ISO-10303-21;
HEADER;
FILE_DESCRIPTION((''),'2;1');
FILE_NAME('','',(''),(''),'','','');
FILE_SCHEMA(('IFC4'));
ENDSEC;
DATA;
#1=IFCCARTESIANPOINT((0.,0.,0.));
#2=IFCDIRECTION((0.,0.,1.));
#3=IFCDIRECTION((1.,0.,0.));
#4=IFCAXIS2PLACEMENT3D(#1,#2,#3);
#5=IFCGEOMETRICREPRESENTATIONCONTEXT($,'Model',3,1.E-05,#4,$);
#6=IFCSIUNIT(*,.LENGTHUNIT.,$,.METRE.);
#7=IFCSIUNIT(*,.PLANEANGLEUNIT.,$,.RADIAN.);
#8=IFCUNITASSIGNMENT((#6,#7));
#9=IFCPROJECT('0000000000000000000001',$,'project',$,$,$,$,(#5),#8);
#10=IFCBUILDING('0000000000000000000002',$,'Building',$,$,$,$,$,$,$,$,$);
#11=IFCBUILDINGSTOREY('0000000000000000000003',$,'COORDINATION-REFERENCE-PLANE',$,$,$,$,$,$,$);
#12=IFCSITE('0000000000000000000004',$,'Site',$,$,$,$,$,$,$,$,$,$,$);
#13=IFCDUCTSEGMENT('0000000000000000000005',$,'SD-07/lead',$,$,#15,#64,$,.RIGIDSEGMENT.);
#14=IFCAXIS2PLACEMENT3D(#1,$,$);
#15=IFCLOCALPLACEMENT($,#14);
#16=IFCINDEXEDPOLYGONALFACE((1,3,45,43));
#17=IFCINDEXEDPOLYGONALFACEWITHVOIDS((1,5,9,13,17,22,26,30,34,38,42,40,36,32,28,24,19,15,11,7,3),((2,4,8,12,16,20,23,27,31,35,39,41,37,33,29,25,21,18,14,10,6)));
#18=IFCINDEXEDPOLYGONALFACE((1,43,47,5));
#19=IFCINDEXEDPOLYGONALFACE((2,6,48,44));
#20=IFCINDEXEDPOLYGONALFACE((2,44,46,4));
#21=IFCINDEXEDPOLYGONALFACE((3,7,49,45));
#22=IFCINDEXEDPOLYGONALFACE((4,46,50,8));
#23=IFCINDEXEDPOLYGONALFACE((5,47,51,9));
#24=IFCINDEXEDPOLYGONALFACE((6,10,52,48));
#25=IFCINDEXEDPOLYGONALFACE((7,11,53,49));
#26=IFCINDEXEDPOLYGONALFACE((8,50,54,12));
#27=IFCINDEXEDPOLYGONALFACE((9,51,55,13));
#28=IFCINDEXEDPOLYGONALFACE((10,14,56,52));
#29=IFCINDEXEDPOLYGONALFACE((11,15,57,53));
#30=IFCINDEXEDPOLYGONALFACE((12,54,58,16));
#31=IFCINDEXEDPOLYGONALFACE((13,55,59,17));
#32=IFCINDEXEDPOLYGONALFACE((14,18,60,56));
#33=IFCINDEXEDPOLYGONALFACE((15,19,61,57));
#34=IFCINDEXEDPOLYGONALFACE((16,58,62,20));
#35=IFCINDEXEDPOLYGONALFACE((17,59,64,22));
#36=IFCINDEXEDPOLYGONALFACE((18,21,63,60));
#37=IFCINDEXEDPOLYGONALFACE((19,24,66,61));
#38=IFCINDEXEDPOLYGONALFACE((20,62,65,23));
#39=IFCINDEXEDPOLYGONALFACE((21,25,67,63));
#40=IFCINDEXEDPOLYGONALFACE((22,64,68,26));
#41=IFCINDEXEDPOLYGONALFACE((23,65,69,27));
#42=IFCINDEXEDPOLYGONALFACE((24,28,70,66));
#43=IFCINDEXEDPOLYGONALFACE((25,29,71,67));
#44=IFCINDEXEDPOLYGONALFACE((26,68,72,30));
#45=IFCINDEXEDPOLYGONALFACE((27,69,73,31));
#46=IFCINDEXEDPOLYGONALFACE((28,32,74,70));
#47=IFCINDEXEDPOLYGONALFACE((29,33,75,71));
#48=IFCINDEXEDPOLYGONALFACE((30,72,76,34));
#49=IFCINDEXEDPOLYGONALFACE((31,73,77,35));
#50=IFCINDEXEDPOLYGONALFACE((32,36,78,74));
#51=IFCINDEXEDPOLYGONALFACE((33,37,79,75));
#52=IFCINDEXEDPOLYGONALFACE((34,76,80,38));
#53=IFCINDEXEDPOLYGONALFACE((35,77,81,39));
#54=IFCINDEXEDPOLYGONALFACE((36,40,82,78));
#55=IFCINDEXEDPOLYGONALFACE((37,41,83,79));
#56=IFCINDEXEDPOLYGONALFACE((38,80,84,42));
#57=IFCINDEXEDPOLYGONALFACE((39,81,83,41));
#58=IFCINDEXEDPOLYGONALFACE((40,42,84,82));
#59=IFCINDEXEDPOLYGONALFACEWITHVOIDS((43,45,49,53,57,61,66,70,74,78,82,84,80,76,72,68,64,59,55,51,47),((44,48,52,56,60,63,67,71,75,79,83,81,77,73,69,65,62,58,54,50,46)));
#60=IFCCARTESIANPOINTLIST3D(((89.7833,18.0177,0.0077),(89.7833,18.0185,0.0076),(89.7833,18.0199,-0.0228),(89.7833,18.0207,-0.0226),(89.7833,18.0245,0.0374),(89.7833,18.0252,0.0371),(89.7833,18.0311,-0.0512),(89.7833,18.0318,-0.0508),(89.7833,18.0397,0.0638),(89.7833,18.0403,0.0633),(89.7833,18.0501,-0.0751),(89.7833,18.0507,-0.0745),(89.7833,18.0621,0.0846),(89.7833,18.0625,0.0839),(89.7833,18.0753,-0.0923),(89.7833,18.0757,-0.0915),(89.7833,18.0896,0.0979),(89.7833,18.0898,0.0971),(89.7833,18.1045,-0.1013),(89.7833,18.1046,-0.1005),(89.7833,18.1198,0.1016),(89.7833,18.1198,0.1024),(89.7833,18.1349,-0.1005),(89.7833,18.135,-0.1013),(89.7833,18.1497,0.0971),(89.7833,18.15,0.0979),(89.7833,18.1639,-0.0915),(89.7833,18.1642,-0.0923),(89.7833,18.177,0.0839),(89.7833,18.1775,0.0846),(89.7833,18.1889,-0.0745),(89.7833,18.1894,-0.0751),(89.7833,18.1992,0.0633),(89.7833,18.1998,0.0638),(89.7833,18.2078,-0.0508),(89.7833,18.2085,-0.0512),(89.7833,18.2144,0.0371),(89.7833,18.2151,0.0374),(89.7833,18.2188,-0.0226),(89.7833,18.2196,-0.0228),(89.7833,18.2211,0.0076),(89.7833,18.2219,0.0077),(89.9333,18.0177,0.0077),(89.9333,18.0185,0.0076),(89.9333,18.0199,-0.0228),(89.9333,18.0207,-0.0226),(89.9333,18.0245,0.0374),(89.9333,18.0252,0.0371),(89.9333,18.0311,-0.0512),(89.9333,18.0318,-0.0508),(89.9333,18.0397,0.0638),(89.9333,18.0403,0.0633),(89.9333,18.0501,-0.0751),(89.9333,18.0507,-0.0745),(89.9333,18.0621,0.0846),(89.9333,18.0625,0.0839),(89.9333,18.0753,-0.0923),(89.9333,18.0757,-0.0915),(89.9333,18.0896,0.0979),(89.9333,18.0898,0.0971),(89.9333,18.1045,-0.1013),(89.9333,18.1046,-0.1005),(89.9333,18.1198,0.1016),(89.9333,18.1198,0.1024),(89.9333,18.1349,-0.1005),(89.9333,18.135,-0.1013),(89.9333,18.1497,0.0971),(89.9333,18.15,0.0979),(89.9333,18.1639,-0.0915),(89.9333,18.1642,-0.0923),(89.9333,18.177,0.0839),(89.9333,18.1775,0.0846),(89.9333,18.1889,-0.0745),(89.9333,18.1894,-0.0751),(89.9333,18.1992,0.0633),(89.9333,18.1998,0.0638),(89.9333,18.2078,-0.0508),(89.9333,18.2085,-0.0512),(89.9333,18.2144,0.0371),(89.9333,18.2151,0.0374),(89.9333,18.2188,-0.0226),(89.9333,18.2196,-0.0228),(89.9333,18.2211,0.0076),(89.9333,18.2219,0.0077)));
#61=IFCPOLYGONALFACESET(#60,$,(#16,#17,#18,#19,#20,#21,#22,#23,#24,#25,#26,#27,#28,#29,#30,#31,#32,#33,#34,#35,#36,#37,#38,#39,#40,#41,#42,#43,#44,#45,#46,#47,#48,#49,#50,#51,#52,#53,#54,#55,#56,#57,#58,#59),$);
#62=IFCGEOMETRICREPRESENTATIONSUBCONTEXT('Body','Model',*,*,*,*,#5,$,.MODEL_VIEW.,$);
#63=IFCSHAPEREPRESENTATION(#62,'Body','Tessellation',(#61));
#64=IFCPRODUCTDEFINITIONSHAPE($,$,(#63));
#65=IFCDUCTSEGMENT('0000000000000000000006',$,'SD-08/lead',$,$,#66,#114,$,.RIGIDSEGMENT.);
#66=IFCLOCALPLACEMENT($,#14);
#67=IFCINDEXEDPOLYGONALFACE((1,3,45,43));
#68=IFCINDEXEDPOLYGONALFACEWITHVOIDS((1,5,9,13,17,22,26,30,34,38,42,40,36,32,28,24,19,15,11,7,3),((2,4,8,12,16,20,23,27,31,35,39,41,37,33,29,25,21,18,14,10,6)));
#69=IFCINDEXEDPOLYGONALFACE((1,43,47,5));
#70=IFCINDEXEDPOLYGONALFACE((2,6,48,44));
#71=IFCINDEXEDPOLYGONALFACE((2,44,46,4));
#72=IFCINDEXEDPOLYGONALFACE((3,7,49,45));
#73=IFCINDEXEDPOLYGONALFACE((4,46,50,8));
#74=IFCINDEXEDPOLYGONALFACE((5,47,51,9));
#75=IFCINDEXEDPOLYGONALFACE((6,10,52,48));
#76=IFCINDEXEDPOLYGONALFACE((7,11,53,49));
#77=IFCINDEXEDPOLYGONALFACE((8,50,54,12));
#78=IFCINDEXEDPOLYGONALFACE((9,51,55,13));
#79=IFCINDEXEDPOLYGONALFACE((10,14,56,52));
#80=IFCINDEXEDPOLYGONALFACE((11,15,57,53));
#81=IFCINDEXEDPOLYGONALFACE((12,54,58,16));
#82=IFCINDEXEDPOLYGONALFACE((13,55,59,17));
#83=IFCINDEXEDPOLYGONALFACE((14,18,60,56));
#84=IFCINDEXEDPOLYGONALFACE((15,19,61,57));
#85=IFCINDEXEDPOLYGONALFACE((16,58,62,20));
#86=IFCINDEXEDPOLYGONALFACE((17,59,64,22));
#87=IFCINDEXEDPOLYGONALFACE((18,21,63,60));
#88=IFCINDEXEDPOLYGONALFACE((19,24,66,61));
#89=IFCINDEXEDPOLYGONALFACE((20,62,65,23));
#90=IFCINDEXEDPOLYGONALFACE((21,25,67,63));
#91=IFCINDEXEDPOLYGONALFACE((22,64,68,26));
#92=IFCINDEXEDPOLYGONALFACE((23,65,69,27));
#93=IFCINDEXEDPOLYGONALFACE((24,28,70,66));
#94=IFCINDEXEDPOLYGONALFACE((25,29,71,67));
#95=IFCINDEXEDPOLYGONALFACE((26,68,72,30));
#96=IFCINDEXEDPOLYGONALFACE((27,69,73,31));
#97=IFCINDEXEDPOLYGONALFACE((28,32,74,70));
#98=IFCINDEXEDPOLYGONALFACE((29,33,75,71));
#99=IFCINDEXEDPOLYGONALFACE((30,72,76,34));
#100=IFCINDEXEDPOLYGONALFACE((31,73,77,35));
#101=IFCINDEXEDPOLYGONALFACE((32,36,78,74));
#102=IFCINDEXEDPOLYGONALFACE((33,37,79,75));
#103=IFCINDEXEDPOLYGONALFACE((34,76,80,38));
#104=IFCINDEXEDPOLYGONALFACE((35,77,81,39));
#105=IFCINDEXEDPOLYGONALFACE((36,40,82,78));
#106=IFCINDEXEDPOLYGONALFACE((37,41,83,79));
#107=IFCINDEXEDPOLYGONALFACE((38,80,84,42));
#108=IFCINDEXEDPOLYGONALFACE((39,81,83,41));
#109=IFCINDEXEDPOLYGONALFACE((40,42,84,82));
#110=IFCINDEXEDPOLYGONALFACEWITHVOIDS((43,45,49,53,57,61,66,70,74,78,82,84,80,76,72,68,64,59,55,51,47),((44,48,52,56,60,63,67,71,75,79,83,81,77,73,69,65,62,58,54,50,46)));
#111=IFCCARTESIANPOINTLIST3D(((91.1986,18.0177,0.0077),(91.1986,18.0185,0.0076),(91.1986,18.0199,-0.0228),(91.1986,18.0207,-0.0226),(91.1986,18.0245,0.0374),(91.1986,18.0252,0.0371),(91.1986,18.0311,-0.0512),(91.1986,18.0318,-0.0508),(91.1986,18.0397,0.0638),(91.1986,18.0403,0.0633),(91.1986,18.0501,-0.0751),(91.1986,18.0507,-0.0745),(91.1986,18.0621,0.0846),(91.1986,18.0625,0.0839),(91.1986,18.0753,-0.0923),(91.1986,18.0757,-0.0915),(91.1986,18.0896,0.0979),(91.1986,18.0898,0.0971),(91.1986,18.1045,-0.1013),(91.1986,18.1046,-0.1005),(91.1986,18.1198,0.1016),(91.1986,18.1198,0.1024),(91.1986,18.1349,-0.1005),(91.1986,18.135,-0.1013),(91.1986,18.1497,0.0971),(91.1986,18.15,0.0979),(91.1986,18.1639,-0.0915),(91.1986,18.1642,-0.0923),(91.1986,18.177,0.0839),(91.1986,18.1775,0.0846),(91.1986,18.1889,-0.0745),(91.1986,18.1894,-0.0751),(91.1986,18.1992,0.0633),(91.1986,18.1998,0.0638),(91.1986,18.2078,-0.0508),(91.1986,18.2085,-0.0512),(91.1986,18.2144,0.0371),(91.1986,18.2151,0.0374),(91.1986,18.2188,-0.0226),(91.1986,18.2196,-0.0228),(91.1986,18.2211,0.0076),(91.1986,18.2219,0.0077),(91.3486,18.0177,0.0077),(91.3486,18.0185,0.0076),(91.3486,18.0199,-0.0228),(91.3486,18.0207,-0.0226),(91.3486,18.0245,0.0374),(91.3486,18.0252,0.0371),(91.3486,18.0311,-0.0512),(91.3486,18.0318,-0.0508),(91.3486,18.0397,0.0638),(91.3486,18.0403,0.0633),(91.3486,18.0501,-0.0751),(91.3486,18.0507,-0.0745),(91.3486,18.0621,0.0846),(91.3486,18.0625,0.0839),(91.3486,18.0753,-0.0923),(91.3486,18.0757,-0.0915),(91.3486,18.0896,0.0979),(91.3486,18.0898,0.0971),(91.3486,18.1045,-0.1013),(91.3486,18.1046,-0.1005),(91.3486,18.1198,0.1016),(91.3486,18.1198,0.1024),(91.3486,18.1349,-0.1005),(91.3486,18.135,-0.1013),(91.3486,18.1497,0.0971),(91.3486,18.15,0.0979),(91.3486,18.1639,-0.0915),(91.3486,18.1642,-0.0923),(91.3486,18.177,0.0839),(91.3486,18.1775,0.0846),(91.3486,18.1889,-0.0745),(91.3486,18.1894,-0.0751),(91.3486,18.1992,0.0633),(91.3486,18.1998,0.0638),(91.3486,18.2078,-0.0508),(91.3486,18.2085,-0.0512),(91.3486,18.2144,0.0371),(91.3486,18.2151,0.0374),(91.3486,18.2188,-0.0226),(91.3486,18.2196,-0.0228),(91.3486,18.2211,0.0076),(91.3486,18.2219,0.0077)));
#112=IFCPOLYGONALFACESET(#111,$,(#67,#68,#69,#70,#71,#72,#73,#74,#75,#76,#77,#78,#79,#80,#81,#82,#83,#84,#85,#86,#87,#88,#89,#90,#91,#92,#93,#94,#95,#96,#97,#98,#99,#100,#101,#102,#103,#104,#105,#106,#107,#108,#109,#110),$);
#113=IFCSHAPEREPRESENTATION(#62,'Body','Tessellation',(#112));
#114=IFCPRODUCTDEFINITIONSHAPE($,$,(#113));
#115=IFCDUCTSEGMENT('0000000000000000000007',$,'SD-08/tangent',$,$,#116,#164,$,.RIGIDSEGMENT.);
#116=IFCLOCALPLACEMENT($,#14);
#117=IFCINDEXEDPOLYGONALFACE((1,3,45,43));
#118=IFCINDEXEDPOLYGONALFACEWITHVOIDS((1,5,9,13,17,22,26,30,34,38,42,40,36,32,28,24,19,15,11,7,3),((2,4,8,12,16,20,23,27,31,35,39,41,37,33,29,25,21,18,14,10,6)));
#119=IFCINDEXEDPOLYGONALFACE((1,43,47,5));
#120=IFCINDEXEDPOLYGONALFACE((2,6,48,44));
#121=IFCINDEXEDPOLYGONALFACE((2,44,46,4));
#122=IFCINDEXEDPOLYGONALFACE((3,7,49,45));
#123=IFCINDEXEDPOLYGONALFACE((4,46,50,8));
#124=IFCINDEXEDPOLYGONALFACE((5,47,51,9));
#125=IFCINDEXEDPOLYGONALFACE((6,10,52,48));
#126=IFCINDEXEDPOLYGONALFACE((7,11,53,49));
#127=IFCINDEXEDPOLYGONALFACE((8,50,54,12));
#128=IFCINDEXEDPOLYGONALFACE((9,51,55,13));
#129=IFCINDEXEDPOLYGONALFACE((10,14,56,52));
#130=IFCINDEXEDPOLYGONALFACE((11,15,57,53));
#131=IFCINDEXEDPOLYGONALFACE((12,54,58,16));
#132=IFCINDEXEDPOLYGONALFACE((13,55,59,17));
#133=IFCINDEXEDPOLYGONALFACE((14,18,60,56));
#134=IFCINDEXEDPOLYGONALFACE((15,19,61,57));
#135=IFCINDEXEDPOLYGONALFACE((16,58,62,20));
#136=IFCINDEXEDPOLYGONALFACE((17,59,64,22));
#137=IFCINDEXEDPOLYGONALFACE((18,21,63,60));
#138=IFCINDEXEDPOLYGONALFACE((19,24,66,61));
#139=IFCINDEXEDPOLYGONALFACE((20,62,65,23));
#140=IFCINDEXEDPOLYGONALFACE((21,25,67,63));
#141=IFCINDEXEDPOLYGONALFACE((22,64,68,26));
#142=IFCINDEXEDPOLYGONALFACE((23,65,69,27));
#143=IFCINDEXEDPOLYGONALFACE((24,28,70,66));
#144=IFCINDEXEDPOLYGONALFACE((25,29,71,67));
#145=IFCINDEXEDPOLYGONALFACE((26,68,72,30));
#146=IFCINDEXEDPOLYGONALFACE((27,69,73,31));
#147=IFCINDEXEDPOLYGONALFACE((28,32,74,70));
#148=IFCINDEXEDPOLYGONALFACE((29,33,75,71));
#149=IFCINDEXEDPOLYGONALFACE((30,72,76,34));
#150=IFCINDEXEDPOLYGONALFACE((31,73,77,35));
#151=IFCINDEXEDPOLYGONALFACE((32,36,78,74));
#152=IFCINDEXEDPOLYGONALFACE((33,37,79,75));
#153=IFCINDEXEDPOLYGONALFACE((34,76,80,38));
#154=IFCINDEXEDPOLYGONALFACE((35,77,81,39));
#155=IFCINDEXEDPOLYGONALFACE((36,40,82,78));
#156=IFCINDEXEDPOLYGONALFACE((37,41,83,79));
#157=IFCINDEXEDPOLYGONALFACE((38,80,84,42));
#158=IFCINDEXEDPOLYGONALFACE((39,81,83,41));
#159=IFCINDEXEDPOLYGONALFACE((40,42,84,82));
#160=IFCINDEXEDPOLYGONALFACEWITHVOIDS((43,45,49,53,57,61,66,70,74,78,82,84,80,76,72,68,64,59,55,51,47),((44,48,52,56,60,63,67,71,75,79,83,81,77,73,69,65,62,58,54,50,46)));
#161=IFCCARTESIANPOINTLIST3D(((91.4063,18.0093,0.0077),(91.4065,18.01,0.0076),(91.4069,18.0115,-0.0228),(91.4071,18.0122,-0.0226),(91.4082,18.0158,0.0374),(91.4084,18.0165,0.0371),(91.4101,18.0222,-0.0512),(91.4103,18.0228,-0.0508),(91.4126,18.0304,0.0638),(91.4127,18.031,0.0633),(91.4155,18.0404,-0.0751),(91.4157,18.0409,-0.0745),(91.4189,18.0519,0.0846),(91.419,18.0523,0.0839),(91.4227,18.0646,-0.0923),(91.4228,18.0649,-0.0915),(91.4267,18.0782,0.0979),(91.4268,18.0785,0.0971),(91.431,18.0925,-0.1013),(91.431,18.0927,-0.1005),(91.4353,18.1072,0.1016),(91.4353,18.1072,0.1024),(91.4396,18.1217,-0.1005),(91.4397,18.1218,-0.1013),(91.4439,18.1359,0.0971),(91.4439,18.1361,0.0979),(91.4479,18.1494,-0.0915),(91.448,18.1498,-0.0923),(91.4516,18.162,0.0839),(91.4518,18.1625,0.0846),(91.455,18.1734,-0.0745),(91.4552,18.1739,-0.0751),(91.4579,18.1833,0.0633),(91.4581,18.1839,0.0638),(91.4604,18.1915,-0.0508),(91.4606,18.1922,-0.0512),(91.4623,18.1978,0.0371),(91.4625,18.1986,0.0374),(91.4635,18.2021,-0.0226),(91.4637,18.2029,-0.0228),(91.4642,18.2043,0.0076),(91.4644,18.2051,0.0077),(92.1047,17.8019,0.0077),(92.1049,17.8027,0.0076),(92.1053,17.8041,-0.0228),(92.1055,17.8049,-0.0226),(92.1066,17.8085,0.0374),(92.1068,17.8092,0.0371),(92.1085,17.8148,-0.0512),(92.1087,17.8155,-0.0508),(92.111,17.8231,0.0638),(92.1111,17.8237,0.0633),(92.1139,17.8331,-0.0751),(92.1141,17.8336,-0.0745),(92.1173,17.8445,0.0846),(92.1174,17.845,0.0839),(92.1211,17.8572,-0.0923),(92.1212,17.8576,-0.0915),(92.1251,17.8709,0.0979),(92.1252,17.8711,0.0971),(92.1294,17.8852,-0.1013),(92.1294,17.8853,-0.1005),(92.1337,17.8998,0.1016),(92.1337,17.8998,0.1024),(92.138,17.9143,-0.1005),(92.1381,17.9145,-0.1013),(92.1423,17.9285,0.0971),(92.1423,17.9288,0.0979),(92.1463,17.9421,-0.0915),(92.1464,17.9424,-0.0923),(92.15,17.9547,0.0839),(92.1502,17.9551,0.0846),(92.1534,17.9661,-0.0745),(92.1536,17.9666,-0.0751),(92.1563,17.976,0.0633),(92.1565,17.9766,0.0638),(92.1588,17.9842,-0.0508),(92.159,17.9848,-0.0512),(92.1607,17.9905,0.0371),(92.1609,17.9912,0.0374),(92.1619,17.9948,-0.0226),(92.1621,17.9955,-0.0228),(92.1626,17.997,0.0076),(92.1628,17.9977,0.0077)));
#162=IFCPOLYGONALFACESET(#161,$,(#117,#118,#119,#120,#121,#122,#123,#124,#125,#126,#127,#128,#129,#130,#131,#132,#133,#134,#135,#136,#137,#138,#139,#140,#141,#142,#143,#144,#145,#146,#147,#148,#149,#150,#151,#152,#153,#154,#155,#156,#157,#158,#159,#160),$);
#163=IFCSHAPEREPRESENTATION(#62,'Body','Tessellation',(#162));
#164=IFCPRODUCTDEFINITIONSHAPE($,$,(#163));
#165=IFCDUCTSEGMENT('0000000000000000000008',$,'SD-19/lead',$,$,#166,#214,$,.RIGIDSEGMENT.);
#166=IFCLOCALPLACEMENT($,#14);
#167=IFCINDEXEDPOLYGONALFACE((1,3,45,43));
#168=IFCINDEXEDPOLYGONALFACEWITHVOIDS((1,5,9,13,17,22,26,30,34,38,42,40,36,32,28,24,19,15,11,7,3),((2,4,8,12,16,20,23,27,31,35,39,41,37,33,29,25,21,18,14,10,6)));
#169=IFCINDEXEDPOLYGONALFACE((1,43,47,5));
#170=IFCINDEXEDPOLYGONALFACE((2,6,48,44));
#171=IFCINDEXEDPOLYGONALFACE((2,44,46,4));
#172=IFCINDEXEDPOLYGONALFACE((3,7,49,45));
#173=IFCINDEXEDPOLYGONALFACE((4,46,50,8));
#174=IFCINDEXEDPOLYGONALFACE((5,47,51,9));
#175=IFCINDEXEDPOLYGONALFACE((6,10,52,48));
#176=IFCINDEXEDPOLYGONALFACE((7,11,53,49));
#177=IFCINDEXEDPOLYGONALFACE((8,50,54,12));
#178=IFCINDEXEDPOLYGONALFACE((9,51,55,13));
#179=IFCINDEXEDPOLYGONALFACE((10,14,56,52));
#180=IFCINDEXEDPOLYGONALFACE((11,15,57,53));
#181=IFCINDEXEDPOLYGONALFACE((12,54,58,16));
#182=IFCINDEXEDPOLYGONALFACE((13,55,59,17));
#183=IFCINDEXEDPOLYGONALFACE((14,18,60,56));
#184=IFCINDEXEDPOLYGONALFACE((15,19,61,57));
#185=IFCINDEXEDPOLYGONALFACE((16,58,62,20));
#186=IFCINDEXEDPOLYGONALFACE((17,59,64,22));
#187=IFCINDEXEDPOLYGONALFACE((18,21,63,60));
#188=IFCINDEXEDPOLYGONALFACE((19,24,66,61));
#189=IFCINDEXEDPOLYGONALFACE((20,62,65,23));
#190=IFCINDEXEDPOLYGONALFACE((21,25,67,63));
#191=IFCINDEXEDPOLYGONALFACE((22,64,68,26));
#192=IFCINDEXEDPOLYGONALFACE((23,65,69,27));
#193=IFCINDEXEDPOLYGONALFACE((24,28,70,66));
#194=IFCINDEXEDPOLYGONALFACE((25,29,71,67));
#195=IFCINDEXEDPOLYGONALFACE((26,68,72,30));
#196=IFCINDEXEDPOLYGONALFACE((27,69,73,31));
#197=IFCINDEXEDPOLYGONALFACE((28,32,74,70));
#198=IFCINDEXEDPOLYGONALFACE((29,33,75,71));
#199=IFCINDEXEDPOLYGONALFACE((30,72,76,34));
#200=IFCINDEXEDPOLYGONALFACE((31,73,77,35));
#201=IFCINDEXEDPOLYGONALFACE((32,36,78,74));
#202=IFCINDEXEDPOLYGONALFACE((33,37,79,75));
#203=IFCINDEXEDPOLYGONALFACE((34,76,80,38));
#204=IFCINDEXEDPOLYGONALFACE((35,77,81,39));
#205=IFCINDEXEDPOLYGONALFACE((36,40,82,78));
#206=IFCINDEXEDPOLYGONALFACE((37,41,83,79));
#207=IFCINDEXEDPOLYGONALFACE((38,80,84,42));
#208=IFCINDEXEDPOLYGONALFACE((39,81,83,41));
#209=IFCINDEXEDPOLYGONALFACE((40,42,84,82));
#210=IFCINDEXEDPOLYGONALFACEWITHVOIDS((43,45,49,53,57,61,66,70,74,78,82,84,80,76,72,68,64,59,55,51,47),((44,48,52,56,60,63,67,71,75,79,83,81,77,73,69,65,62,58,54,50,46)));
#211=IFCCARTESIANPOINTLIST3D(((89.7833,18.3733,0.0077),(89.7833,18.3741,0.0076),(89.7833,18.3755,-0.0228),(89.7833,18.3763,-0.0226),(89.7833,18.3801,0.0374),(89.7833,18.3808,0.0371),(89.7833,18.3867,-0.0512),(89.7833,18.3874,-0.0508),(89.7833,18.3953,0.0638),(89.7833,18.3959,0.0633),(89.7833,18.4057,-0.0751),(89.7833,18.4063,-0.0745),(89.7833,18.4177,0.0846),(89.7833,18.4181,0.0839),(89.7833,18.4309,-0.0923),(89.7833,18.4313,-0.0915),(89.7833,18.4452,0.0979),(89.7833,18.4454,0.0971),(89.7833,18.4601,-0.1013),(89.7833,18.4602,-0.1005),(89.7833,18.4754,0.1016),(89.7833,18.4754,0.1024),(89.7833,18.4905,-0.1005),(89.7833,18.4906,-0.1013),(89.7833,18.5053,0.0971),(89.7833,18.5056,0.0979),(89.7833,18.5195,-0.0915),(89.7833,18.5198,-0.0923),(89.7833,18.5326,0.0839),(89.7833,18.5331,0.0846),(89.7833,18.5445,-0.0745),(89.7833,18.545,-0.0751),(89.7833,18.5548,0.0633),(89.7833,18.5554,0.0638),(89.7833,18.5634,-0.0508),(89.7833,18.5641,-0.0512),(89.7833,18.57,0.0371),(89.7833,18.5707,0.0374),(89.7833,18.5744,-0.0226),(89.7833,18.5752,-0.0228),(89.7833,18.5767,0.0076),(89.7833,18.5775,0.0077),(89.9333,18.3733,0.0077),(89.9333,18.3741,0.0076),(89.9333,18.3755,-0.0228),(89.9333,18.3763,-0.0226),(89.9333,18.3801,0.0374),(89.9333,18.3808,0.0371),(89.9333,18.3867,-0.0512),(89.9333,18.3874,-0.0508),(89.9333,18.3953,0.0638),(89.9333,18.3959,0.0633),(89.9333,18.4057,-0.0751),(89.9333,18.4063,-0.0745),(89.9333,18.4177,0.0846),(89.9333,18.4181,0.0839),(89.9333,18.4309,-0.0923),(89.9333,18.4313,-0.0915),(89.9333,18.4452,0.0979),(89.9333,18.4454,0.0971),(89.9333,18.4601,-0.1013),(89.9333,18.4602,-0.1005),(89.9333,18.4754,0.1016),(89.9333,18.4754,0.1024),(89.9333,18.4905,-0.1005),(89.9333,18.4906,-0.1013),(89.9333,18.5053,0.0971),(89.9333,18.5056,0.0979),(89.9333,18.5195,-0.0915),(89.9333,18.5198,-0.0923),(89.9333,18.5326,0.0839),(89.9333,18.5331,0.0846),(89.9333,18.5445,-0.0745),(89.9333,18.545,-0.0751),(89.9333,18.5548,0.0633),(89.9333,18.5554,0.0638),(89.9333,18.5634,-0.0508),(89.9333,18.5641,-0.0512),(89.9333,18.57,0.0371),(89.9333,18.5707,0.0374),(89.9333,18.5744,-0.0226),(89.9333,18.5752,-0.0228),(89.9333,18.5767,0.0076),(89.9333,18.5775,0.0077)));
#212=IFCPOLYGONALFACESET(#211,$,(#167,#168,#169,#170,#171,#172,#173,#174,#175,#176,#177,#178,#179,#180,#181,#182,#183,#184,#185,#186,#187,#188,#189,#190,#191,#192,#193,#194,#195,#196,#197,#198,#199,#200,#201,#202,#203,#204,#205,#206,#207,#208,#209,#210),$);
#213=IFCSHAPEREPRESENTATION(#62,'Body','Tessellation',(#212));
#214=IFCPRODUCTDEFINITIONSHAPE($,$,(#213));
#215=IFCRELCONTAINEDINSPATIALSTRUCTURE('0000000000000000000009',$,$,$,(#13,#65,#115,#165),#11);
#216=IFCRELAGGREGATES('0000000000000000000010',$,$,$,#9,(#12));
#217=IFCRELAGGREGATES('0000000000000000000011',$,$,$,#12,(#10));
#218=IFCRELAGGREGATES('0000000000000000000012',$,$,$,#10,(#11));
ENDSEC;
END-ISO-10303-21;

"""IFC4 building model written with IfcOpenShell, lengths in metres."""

from ifc_helpers import new_model, si_unit, frame, origin_with_axes, place, context, subcontext, project, spatial, hollow_circle, extrude, element, save


model = new_model("IFC4")

# Units and contexts
model_context = context("Model", 3, precision=1e-05, world=origin_with_axes())
body_context_1 = subcontext(model_context, "Body", "Model", "MODEL_VIEW")
ifc_project = project(units=[si_unit("LENGTHUNIT", "METRE"), si_unit("PLANEANGLEUNIT", "RADIAN")], contexts=[model_context])

# Site, building, storey
site = spatial("IfcSite", under=ifc_project, Name="Site")
building = spatial("IfcBuilding", under=site, Name="Building")
storey = spatial("IfcBuildingStorey", under=building, Name="COORDINATION-REFERENCE-PLANE")

# Duct segments
for number, where, z_axis, x_axis, name in (
    (1, (89.9333, 18.1198, 0.0), (-1.0, 0.0, 0.0), (0.0, 0.0, 1.0), "SD-07/lead"),
    (2, (91.1986, 18.1198, 0.0), (1.0, 0.0, 0.0), (0.0, 0.0, 1.0), "SD-08/lead"),
):
    element("IfcDuctSegment", number, at=place(None, frame(where, z_axis=z_axis, x_axis=x_axis)), inside=storey, Name=name, PredefinedType="RIGIDSEGMENT", context=body_context_1, shape_type="SweptSolid", body=[
        extrude(hollow_circle(Radius=0.1024, WallThickness=0.0008), origin_with_axes(), (0.0, 0.0, 1.0), 0.15),
    ])

# Duct segment
duct_segment_1_placement = place(None, frame((91.4353, 18.1072, 0.0), z_axis=(0.958645, -0.284603, 0.0), x_axis=(0.0, 0.0, 1.0)))
element("IfcDuctSegment", 3, at=duct_segment_1_placement, inside=storey, Name="SD-08/tangent", PredefinedType="RIGIDSEGMENT", context=body_context_1, shape_type="SweptSolid", body=[
    extrude(hollow_circle(Radius=0.1024, WallThickness=0.0008), origin_with_axes(), (0.0, 0.0, 1.0), 0.7285),
])

# Duct segment
for number, where, z_axis, x_axis, name in (
    (4, (89.9333, 18.4754, 0.0), (-1.0, 0.0, 0.0), (0.0, 0.0, 1.0), "SD-19/lead"),
):
    element("IfcDuctSegment", number, at=place(None, frame(where, z_axis=z_axis, x_axis=x_axis)), inside=storey, Name=name, PredefinedType="RIGIDSEGMENT", context=body_context_1, shape_type="SweptSolid", body=[
        extrude(hollow_circle(Radius=0.1024, WallThickness=0.0008), origin_with_axes(), (0.0, 0.0, 1.0), 0.15),
    ])

save(model, "model.ifc")
